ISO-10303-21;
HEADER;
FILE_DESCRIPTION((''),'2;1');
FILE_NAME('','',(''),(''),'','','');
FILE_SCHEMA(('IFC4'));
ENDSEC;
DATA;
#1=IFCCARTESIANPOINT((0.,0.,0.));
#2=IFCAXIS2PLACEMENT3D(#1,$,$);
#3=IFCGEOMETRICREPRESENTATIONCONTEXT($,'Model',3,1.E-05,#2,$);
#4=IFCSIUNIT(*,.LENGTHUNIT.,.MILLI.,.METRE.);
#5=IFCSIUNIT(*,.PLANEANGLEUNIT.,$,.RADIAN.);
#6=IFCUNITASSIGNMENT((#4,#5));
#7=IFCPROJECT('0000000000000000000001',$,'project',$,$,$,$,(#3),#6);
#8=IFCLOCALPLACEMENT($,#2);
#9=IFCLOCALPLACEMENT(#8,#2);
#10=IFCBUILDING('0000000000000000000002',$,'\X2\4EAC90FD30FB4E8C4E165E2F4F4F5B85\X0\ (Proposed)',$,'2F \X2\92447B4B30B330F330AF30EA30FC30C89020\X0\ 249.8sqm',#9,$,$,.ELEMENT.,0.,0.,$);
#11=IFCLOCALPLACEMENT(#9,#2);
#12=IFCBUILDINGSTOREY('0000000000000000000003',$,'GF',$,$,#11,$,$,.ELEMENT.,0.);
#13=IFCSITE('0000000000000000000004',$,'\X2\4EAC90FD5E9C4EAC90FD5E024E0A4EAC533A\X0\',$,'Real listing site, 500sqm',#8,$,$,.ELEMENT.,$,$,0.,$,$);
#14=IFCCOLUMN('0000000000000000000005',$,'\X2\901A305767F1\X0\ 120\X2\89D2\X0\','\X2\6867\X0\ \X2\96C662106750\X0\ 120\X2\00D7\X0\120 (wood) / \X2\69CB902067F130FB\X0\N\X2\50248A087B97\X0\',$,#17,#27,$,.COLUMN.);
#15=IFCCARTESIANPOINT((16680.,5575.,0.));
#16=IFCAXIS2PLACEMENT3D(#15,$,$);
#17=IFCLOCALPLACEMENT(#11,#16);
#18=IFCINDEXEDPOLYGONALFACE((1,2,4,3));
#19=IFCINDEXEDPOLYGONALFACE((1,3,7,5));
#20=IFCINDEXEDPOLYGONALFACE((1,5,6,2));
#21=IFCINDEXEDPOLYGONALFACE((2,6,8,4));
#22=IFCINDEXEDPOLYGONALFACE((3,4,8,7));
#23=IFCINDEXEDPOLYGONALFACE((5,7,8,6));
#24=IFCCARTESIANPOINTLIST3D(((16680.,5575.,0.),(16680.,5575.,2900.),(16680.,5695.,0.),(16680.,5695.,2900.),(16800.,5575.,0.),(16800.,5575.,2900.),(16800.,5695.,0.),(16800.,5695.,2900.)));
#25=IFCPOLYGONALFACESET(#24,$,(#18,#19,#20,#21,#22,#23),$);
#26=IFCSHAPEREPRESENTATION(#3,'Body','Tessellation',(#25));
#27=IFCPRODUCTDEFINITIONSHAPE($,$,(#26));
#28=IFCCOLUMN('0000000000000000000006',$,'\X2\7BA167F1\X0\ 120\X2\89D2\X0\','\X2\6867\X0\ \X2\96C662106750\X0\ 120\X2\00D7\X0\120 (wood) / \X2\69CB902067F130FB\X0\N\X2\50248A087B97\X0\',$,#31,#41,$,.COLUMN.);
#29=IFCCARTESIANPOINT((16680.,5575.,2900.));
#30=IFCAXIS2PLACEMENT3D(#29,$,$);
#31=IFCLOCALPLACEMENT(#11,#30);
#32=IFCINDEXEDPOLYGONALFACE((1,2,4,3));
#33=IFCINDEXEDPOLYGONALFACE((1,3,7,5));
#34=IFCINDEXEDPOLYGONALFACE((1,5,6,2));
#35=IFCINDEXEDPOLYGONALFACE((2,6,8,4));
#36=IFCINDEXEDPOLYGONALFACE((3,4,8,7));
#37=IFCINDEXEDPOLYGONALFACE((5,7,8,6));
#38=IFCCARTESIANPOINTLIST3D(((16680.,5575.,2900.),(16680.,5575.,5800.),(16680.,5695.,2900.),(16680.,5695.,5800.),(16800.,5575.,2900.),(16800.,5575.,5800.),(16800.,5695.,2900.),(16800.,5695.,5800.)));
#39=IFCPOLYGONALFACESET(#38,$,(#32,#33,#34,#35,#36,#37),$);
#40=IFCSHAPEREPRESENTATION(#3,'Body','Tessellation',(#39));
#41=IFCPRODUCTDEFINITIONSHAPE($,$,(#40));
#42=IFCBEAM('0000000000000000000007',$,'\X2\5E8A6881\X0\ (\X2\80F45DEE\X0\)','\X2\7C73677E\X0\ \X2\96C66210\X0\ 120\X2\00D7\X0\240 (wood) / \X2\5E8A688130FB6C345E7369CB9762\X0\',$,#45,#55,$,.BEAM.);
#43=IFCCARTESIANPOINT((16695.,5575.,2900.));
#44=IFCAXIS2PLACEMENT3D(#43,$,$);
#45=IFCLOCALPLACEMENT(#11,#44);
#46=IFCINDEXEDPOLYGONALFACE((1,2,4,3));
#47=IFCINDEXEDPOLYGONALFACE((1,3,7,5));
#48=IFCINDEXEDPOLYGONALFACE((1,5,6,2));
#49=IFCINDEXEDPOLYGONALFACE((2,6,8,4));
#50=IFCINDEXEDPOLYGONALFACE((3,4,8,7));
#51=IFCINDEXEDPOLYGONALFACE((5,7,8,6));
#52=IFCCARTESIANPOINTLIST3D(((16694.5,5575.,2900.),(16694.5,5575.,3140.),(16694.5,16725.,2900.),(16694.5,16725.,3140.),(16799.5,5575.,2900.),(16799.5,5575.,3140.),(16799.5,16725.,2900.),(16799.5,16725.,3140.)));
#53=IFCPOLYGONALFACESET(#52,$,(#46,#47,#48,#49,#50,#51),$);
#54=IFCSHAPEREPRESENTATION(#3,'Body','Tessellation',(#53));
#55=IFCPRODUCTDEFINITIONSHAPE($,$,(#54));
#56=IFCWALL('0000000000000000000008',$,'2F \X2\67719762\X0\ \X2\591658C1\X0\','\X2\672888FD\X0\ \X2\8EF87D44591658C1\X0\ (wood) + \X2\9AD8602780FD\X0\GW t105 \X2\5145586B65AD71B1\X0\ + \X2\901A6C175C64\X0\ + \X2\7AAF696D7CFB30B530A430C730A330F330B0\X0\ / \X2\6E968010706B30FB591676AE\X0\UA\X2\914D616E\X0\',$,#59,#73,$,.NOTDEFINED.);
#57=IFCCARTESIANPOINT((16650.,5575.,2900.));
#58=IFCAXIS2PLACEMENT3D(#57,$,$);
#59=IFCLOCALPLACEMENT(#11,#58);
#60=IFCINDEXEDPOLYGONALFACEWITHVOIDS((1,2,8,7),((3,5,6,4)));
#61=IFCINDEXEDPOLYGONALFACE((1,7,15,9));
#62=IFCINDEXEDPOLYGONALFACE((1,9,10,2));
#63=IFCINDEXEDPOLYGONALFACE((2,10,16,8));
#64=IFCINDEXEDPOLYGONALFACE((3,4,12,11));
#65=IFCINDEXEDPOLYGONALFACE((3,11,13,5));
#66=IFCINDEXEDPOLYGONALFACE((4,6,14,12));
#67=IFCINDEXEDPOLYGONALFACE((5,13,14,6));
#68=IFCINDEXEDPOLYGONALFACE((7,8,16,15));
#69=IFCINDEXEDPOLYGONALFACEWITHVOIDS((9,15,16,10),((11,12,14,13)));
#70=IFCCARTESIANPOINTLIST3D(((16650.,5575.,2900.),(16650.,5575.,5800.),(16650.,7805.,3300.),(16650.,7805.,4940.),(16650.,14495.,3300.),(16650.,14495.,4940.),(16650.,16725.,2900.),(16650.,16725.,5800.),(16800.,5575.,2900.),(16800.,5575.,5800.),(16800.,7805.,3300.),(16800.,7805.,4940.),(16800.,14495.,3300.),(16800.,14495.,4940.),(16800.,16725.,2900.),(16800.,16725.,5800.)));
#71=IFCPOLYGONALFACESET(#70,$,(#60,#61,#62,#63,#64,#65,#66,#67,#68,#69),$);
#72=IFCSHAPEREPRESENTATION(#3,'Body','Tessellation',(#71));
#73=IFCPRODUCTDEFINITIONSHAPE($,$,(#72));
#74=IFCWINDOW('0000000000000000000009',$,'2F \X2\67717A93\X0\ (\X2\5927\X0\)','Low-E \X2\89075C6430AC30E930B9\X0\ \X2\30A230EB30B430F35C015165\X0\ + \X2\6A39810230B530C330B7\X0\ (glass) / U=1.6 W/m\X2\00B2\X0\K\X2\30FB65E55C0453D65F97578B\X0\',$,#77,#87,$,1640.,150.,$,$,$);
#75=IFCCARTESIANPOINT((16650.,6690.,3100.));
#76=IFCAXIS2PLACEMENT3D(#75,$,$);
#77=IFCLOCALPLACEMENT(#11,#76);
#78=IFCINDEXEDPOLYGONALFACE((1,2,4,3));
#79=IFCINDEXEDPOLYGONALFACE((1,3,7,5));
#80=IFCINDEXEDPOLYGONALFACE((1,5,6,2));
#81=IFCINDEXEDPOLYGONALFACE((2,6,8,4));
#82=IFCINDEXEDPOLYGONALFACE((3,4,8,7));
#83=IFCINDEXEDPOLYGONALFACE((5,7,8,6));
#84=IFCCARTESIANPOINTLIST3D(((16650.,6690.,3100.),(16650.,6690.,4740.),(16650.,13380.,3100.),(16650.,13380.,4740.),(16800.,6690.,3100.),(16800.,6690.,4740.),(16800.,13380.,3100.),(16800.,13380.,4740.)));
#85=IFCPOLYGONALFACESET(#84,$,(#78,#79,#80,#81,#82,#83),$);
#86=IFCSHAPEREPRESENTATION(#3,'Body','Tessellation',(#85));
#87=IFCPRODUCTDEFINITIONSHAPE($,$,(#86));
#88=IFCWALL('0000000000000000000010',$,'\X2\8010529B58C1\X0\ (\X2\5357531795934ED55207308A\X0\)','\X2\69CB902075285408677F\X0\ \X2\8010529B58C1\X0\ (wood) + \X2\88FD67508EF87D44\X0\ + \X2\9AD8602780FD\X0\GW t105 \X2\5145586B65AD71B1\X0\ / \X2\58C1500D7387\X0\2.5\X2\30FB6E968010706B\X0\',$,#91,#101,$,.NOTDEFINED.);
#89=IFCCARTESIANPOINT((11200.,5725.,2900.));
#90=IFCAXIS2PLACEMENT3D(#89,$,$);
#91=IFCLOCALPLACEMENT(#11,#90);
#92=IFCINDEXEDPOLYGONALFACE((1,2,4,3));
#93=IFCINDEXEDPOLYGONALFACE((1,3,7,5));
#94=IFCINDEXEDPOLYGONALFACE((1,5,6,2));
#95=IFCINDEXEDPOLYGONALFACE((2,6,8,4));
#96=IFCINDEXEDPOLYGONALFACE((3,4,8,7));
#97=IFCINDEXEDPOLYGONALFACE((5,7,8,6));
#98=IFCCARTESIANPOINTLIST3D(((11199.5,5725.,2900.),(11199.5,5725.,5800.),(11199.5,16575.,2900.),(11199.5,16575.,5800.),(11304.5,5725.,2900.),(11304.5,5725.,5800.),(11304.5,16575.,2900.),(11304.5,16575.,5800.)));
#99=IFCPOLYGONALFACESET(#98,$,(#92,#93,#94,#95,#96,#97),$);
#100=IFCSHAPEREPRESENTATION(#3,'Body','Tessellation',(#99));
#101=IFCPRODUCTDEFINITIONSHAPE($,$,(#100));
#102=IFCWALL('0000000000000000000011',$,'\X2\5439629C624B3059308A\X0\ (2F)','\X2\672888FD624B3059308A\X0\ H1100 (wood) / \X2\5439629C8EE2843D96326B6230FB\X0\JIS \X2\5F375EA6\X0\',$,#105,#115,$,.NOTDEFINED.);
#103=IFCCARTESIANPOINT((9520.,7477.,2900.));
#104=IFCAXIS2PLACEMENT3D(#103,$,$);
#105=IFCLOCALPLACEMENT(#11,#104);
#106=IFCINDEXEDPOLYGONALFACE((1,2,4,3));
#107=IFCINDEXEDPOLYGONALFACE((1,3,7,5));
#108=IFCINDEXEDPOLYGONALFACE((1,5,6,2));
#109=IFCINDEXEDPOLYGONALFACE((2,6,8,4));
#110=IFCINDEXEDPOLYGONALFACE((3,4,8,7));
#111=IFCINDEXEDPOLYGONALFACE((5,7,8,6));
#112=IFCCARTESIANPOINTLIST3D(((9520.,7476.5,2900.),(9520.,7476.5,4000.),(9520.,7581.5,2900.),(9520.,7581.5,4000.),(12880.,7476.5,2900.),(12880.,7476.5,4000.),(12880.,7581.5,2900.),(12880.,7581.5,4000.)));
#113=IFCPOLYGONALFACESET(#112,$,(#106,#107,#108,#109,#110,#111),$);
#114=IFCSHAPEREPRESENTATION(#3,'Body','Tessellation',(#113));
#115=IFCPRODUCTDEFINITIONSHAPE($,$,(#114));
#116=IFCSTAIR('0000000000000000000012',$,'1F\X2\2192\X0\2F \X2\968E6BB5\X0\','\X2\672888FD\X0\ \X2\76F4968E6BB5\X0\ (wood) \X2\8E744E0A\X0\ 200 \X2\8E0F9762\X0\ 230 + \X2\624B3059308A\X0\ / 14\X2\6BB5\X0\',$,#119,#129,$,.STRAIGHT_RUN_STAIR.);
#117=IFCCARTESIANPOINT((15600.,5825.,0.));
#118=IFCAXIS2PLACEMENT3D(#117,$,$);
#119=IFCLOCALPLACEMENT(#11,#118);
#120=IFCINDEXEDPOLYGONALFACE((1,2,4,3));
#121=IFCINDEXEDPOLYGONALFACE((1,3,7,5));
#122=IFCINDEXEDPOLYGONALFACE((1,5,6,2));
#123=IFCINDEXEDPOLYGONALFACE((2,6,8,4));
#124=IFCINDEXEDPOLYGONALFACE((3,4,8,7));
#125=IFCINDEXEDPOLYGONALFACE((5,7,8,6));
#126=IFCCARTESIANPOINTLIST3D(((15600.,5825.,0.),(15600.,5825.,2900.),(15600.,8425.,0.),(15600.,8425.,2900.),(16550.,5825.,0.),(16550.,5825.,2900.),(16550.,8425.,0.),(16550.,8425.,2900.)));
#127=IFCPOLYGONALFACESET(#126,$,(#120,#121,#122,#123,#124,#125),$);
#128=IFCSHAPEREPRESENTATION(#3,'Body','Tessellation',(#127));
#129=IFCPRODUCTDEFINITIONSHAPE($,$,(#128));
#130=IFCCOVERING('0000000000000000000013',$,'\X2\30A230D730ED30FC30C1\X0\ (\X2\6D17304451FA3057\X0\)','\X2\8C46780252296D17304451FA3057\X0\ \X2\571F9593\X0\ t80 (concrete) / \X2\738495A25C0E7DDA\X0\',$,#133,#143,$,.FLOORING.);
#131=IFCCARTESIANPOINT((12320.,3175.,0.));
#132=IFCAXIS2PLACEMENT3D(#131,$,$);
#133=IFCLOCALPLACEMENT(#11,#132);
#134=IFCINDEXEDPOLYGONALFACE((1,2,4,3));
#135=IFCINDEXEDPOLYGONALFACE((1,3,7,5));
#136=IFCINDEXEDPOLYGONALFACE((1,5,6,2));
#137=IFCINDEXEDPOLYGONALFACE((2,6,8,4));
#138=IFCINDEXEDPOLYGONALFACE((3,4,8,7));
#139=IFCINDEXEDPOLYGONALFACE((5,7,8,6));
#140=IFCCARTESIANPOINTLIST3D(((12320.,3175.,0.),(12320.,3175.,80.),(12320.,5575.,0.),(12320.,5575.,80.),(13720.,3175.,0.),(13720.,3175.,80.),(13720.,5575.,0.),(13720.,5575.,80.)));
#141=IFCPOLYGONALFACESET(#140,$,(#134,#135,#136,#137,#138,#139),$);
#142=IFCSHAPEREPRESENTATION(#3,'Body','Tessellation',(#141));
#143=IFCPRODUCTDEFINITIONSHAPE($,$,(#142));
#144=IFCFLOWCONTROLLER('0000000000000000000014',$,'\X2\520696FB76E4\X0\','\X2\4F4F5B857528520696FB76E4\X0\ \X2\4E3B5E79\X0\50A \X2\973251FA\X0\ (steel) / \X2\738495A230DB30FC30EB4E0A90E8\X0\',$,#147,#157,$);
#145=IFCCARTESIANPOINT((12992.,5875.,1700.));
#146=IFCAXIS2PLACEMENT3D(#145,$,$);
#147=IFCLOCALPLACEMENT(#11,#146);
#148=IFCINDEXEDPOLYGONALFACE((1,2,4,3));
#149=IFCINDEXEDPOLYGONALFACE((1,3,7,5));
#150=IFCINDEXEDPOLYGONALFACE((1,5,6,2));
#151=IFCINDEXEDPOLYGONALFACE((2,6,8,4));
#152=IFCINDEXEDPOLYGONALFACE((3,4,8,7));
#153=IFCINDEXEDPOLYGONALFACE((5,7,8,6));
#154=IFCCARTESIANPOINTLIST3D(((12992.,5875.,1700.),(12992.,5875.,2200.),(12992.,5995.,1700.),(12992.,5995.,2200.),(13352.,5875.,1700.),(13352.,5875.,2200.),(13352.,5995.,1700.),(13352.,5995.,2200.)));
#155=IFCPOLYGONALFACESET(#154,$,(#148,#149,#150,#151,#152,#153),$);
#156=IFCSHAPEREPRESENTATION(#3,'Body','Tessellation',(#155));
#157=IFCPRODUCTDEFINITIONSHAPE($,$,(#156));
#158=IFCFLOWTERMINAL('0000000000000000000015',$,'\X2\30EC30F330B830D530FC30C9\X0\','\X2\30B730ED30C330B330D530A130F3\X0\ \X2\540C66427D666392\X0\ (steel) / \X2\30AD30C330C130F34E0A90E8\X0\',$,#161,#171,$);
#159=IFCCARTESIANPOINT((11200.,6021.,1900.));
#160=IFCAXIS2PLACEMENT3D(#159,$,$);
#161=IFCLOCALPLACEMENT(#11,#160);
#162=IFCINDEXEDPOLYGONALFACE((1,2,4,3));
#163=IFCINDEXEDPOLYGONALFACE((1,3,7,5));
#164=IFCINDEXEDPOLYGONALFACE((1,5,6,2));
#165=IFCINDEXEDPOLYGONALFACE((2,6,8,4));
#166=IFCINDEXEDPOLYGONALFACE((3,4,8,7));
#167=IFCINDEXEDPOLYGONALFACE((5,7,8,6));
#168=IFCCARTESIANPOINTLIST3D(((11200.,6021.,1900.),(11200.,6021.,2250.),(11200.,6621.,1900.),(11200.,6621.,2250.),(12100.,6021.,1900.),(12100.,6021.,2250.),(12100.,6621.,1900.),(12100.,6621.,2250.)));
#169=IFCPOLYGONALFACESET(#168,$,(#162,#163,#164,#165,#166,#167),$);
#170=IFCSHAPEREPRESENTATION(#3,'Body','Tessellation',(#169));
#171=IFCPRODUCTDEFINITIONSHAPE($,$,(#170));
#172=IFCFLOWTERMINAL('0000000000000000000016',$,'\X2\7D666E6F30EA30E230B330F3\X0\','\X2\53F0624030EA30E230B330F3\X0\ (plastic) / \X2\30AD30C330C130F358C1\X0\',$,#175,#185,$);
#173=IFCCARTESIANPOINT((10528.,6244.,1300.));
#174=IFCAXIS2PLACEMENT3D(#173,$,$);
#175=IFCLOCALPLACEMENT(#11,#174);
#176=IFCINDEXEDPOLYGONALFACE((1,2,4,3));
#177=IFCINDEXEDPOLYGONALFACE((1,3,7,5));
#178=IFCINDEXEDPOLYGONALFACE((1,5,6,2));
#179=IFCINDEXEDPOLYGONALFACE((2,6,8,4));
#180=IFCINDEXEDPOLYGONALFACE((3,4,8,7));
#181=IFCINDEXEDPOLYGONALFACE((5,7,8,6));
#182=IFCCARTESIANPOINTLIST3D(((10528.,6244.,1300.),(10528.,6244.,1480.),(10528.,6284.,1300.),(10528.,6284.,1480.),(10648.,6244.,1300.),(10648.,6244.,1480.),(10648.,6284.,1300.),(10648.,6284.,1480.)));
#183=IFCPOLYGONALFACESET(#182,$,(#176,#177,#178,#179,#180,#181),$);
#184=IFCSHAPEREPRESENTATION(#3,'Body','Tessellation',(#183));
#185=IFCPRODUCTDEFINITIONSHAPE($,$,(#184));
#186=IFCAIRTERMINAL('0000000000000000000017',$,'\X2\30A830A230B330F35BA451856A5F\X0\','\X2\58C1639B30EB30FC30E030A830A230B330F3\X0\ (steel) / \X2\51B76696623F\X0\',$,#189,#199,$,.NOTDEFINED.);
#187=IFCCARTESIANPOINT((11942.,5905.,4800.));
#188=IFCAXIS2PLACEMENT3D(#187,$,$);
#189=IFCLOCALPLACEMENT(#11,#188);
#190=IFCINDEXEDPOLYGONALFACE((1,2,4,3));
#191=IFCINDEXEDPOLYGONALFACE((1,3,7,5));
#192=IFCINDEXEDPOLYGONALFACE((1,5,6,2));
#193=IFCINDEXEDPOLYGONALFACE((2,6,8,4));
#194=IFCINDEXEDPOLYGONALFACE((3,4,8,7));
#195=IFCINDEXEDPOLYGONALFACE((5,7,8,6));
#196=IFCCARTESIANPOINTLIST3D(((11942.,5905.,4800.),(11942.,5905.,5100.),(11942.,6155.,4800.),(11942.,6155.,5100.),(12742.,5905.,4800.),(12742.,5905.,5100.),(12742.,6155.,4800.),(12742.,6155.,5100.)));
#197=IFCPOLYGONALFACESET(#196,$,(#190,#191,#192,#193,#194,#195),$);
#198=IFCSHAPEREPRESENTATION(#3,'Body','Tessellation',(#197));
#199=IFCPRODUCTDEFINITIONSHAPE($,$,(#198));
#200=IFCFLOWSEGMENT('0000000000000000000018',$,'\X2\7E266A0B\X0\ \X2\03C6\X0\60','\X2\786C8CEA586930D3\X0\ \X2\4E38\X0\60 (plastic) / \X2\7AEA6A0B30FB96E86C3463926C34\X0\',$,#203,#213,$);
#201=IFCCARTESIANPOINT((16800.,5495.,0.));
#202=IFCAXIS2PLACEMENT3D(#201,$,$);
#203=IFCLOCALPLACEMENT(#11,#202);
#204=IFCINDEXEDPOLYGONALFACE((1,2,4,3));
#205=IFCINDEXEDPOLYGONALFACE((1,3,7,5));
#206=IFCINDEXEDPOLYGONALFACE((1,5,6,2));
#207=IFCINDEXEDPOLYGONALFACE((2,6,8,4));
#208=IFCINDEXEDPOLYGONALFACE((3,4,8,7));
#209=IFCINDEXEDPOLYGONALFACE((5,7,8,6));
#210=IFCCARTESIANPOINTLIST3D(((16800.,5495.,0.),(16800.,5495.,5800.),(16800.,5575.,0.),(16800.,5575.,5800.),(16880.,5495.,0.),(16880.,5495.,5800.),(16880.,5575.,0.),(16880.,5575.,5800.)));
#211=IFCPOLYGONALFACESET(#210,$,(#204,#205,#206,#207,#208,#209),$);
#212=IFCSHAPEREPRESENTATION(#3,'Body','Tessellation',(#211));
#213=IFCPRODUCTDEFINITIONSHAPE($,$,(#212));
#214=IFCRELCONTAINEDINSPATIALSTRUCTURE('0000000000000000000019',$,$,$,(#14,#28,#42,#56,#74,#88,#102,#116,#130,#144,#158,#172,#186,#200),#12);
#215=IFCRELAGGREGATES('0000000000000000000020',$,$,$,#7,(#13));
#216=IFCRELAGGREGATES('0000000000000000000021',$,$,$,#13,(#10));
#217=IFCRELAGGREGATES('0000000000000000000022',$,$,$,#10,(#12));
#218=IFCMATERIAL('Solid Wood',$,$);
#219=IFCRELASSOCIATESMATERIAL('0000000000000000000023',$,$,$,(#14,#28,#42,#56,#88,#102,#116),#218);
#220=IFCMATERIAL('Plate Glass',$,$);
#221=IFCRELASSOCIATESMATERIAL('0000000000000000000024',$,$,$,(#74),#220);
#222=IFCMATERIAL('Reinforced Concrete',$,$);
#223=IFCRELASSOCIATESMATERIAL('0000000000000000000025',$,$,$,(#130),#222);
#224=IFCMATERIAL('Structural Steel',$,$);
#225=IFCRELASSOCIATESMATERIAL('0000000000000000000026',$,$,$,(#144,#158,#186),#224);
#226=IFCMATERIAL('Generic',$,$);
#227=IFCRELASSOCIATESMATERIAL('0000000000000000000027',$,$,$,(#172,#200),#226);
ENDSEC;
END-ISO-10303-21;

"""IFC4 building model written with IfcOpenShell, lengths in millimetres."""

from ifc_helpers import new_model, si_unit, frame, frame_2d, origin, place, context, project, spatial, rectangle, extrude, material, element, fill, save


model = new_model("IFC4")

# Units and contexts
model_context = context("Model", 3, precision=1e-05, world=origin())
ifc_project = project(units=[si_unit("LENGTHUNIT", "METRE", prefix="MILLI"), si_unit("PLANEANGLEUNIT", "RADIAN")], contexts=[model_context])

# Site, building, storey
site_placement = place(None, origin())
site = spatial("IfcSite", under=ifc_project, at=site_placement, Name="京都府京都市上京区", ObjectType="Real listing site, 500sqm", CompositionType="ELEMENT", RefElevation=0.0)
building_placement = place(site_placement, origin())
building = spatial("IfcBuilding", under=site, at=building_placement, Name="京都・二世帯住宅 (Proposed)", ObjectType="2F 鉄筋コンクリート造 249.8sqm", CompositionType="ELEMENT", ElevationOfRefHeight=0.0, ElevationOfTerrain=0.0)
storey_placement = place(building_placement, origin())
storey = spatial("IfcBuildingStorey", under=building, at=storey_placement, Name="GF", CompositionType="ELEMENT", Elevation=0.0)

# Columns
ifc_material_1 = material(Name="Solid Wood")
column_1_placement = place(storey_placement, frame((16680.0, 5575.0, 0.0)))
element("IfcColumn", 1, at=column_1_placement, inside=storey, material=ifc_material_1, Name="通し柱 120角", Description="桧 集成材 120×120 (wood) / 構造柱・N値計算", PredefinedType="COLUMN", context=model_context, shape_type="SweptSolid", body=[
    extrude(rectangle(XDim=120.0, YDim=120.0, at=frame_2d((60.0, 60.0))), frame((16680.0, 5575.0, 0.0)), (0.0, 0.0, 1.0), 2900.0),
])
column_2_placement = place(storey_placement, frame((16680.0, 5575.0, 2900.0)))
element("IfcColumn", 2, at=column_2_placement, inside=storey, material=ifc_material_1, Name="管柱 120角", Description="桧 集成材 120×120 (wood) / 構造柱・N値計算", PredefinedType="COLUMN", context=model_context, shape_type="SweptSolid", body=[
    extrude(rectangle(XDim=120.0, YDim=120.0, at=frame_2d((60.0, 60.0))), frame((16680.0, 5575.0, 2900.0)), (0.0, 0.0, 1.0), 2900.0),
])

# Beam
beam_1_placement = place(storey_placement, frame((16695.0, 5575.0, 2900.0)))
element("IfcBeam", 3, at=beam_1_placement, inside=storey, material=ifc_material_1, Name="床梁 (胴差)", Description="米松 集成 120×240 (wood) / 床梁・水平構面", PredefinedType="BEAM", context=model_context, shape_type="SweptSolid", body=[
    extrude(rectangle(XDim=105.0, YDim=11150.0, at=frame_2d((52.0, 5575.0))), frame((16695.0, 5575.0, 2900.0)), (0.0, 0.0, 1.0), 240.0),
])

# Shared definitions
ifc_material_2 = material(Name="Plate Glass")

# Wall, opening, window
wall_1_placement = place(storey_placement, frame((16650.0, 5575.0, 2900.0)))
wall_1 = element("IfcWall", 4, at=wall_1_placement, inside=storey, material=ifc_material_1, Name="2F 東面 外壁", Description="木製 軸組外壁 (wood) + 高性能GW t105 充填断熱 + 通気層 + 窯業系サイディング / 準耐火・外皮UA配慮", PredefinedType="NOTDEFINED", context=model_context, shape_type="SweptSolid", body=[
    extrude(rectangle(XDim=150.0, YDim=11150.0, at=frame_2d((75.0, 5575.0))), frame((16650.0, 5575.0, 2900.0)), (0.0, 0.0, 1.0), 2900.0),
])
opening_1_placement = place(storey_placement, frame((16650.0, 6690.0, 3100.0)))
opening_1 = element("IfcOpeningElement", 5, at=opening_1_placement, cuts=wall_1, PredefinedType="NOTDEFINED", context=model_context, shape_type="SweptSolid", body=[
    extrude(rectangle(XDim=150.0, YDim=6690.0, at=frame_2d((75.0, 3345.0))), frame((16650.0, 6690.0, 3100.0)), (0.0, 0.0, 1.0), 1640.0),
])
window_1_placement = place(storey_placement, frame((16650.0, 6690.0, 3100.0)))
window_1 = element("IfcWindow", 6, at=window_1_placement, inside=storey, material=ifc_material_2, Name="2F 東窓 (大)", Description="Low-E 複層ガラス アルゴン封入 + 樹脂サッシ (glass) / U=1.6 W/m²K・日射取得型", OverallHeight=1640.0, OverallWidth=150.0, context=model_context, shape_type="SweptSolid", body=[
    extrude(rectangle(XDim=150.0, YDim=6690.0, at=frame_2d((75.0, 3345.0))), frame((16650.0, 6690.0, 3100.0)), (0.0, 0.0, 1.0), 1640.0),
])
fill(opening_1, window_1)

# Walls
wall_2_placement = place(storey_placement, frame((11200.0, 5725.0, 2900.0)))
element("IfcWall", 7, at=wall_2_placement, inside=storey, material=ifc_material_1, Name="耐力壁 (南北間仕切り)", Description="構造用合板 耐力壁 (wood) + 製材軸組 + 高性能GW t105 充填断熱 / 壁倍率2.5・準耐火", PredefinedType="NOTDEFINED", context=model_context, shape_type="SweptSolid", body=[
    extrude(rectangle(XDim=105.0, YDim=10850.0, at=frame_2d((52.0, 5425.0))), frame((11200.0, 5725.0, 2900.0)), (0.0, 0.0, 1.0), 2900.0),
])
wall_3_placement = place(storey_placement, frame((9520.0, 7477.0, 2900.0)))
element("IfcWall", 8, at=wall_3_placement, inside=storey, material=ifc_material_1, Name="吹抜手すり (2F)", Description="木製手すり H1100 (wood) / 吹抜転落防止・JIS 強度", PredefinedType="NOTDEFINED", context=model_context, shape_type="SweptSolid", body=[
    extrude(rectangle(XDim=3360.0, YDim=105.0, at=frame_2d((1680.0, 52.0))), frame((9520.0, 7477.0, 2900.0)), (0.0, 0.0, 1.0), 1100.0),
])

# Stair
stair_placement = place(storey_placement, frame((15600.0, 5825.0, 0.0)))
element("IfcStair", 9, at=stair_placement, inside=storey, material=ifc_material_1, Name="1F→2F 階段", Description="木製 直階段 (wood) 蹴上 200 踏面 230 + 手すり / 14段", PredefinedType="STRAIGHT_RUN_STAIR", context=model_context, shape_type="SweptSolid", body=[
    extrude(rectangle(XDim=950.0, YDim=2600.0, at=frame_2d((475.0, 1300.0))), frame((15600.0, 5825.0, 0.0)), (0.0, 0.0, 1.0), 2900.0),
])

# Covering
ifc_material_3 = material(Name="Reinforced Concrete")
covering_placement = place(storey_placement, frame((12320.0, 3175.0, 0.0)))
element("IfcCovering", 10, at=covering_placement, inside=storey, material=ifc_material_3, Name="アプローチ (洗い出し)", Description="豆砂利洗い出し 土間 t80 (concrete) / 玄関導線", PredefinedType="FLOORING", context=model_context, shape_type="SweptSolid", body=[
    extrude(rectangle(XDim=1400.0, YDim=2400.0, at=frame_2d((700.0, 1200.0))), frame((12320.0, 3175.0, 0.0)), (0.0, 0.0, 1.0), 80.0),
])

# Flow controller
ifc_material_4 = material(Name="Structural Steel")
flow_controller_placement = place(storey_placement, frame((12992.0, 5875.0, 1700.0)))
element("IfcFlowController", 11, at=flow_controller_placement, inside=storey, material=ifc_material_4, Name="分電盤", Description="住宅用分電盤 主幹50A 露出 (steel) / 玄関ホール上部", context=model_context, shape_type="SweptSolid", body=[
    extrude(rectangle(XDim=360.0, YDim=120.0, at=frame_2d((180.0, 60.0))), frame((12992.0, 5875.0, 1700.0)), (0.0, 0.0, 1.0), 500.0),
])

# Flow terminals
flow_terminal_1_placement = place(storey_placement, frame((11200.0, 6021.0, 1900.0)))
element("IfcFlowTerminal", 12, at=flow_terminal_1_placement, inside=storey, material=ifc_material_4, Name="レンジフード", Description="シロッコファン 同時給排 (steel) / キッチン上部", context=model_context, shape_type="SweptSolid", body=[
    extrude(rectangle(XDim=900.0, YDim=600.0, at=frame_2d((450.0, 300.0))), frame((11200.0, 6021.0, 1900.0)), (0.0, 0.0, 1.0), 350.0),
])
ifc_material_5 = material(Name="Generic")
flow_terminal_2_placement = place(storey_placement, frame((10528.0, 6244.0, 1300.0)))
element("IfcFlowTerminal", 13, at=flow_terminal_2_placement, inside=storey, material=ifc_material_5, Name="給湯リモコン", Description="台所リモコン (plastic) / キッチン壁", context=model_context, shape_type="SweptSolid", body=[
    extrude(rectangle(XDim=120.0, YDim=40.0, at=frame_2d((60.0, 20.0))), frame((10528.0, 6244.0, 1300.0)), (0.0, 0.0, 1.0), 180.0),
])

# Air terminal
air_terminal_placement = place(storey_placement, frame((11942.0, 5905.0, 4800.0)))
element("IfcAirTerminal", 14, at=air_terminal_placement, inside=storey, material=ifc_material_4, Name="エアコン室内機", Description="壁掛ルームエアコン (steel) / 冷暖房", PredefinedType="NOTDEFINED", context=model_context, shape_type="SweptSolid", body=[
    extrude(rectangle(XDim=800.0, YDim=250.0, at=frame_2d((400.0, 125.0))), frame((11942.0, 5905.0, 4800.0)), (0.0, 0.0, 1.0), 300.0),
])

# Flow segment
flow_segment_placement = place(storey_placement, frame((16800.0, 5495.0, 0.0)))
element("IfcFlowSegment", 15, at=flow_segment_placement, inside=storey, material=ifc_material_5, Name="縦樋 φ60", Description="硬質塩ビ 丸60 (plastic) / 竪樋・雨水排水", context=model_context, shape_type="SweptSolid", body=[
    extrude(rectangle(XDim=80.0, YDim=80.0, at=frame_2d((40.0, 40.0))), frame((16800.0, 5495.0, 0.0)), (0.0, 0.0, 1.0), 5800.0),
])

save(model, "model.ifc")
